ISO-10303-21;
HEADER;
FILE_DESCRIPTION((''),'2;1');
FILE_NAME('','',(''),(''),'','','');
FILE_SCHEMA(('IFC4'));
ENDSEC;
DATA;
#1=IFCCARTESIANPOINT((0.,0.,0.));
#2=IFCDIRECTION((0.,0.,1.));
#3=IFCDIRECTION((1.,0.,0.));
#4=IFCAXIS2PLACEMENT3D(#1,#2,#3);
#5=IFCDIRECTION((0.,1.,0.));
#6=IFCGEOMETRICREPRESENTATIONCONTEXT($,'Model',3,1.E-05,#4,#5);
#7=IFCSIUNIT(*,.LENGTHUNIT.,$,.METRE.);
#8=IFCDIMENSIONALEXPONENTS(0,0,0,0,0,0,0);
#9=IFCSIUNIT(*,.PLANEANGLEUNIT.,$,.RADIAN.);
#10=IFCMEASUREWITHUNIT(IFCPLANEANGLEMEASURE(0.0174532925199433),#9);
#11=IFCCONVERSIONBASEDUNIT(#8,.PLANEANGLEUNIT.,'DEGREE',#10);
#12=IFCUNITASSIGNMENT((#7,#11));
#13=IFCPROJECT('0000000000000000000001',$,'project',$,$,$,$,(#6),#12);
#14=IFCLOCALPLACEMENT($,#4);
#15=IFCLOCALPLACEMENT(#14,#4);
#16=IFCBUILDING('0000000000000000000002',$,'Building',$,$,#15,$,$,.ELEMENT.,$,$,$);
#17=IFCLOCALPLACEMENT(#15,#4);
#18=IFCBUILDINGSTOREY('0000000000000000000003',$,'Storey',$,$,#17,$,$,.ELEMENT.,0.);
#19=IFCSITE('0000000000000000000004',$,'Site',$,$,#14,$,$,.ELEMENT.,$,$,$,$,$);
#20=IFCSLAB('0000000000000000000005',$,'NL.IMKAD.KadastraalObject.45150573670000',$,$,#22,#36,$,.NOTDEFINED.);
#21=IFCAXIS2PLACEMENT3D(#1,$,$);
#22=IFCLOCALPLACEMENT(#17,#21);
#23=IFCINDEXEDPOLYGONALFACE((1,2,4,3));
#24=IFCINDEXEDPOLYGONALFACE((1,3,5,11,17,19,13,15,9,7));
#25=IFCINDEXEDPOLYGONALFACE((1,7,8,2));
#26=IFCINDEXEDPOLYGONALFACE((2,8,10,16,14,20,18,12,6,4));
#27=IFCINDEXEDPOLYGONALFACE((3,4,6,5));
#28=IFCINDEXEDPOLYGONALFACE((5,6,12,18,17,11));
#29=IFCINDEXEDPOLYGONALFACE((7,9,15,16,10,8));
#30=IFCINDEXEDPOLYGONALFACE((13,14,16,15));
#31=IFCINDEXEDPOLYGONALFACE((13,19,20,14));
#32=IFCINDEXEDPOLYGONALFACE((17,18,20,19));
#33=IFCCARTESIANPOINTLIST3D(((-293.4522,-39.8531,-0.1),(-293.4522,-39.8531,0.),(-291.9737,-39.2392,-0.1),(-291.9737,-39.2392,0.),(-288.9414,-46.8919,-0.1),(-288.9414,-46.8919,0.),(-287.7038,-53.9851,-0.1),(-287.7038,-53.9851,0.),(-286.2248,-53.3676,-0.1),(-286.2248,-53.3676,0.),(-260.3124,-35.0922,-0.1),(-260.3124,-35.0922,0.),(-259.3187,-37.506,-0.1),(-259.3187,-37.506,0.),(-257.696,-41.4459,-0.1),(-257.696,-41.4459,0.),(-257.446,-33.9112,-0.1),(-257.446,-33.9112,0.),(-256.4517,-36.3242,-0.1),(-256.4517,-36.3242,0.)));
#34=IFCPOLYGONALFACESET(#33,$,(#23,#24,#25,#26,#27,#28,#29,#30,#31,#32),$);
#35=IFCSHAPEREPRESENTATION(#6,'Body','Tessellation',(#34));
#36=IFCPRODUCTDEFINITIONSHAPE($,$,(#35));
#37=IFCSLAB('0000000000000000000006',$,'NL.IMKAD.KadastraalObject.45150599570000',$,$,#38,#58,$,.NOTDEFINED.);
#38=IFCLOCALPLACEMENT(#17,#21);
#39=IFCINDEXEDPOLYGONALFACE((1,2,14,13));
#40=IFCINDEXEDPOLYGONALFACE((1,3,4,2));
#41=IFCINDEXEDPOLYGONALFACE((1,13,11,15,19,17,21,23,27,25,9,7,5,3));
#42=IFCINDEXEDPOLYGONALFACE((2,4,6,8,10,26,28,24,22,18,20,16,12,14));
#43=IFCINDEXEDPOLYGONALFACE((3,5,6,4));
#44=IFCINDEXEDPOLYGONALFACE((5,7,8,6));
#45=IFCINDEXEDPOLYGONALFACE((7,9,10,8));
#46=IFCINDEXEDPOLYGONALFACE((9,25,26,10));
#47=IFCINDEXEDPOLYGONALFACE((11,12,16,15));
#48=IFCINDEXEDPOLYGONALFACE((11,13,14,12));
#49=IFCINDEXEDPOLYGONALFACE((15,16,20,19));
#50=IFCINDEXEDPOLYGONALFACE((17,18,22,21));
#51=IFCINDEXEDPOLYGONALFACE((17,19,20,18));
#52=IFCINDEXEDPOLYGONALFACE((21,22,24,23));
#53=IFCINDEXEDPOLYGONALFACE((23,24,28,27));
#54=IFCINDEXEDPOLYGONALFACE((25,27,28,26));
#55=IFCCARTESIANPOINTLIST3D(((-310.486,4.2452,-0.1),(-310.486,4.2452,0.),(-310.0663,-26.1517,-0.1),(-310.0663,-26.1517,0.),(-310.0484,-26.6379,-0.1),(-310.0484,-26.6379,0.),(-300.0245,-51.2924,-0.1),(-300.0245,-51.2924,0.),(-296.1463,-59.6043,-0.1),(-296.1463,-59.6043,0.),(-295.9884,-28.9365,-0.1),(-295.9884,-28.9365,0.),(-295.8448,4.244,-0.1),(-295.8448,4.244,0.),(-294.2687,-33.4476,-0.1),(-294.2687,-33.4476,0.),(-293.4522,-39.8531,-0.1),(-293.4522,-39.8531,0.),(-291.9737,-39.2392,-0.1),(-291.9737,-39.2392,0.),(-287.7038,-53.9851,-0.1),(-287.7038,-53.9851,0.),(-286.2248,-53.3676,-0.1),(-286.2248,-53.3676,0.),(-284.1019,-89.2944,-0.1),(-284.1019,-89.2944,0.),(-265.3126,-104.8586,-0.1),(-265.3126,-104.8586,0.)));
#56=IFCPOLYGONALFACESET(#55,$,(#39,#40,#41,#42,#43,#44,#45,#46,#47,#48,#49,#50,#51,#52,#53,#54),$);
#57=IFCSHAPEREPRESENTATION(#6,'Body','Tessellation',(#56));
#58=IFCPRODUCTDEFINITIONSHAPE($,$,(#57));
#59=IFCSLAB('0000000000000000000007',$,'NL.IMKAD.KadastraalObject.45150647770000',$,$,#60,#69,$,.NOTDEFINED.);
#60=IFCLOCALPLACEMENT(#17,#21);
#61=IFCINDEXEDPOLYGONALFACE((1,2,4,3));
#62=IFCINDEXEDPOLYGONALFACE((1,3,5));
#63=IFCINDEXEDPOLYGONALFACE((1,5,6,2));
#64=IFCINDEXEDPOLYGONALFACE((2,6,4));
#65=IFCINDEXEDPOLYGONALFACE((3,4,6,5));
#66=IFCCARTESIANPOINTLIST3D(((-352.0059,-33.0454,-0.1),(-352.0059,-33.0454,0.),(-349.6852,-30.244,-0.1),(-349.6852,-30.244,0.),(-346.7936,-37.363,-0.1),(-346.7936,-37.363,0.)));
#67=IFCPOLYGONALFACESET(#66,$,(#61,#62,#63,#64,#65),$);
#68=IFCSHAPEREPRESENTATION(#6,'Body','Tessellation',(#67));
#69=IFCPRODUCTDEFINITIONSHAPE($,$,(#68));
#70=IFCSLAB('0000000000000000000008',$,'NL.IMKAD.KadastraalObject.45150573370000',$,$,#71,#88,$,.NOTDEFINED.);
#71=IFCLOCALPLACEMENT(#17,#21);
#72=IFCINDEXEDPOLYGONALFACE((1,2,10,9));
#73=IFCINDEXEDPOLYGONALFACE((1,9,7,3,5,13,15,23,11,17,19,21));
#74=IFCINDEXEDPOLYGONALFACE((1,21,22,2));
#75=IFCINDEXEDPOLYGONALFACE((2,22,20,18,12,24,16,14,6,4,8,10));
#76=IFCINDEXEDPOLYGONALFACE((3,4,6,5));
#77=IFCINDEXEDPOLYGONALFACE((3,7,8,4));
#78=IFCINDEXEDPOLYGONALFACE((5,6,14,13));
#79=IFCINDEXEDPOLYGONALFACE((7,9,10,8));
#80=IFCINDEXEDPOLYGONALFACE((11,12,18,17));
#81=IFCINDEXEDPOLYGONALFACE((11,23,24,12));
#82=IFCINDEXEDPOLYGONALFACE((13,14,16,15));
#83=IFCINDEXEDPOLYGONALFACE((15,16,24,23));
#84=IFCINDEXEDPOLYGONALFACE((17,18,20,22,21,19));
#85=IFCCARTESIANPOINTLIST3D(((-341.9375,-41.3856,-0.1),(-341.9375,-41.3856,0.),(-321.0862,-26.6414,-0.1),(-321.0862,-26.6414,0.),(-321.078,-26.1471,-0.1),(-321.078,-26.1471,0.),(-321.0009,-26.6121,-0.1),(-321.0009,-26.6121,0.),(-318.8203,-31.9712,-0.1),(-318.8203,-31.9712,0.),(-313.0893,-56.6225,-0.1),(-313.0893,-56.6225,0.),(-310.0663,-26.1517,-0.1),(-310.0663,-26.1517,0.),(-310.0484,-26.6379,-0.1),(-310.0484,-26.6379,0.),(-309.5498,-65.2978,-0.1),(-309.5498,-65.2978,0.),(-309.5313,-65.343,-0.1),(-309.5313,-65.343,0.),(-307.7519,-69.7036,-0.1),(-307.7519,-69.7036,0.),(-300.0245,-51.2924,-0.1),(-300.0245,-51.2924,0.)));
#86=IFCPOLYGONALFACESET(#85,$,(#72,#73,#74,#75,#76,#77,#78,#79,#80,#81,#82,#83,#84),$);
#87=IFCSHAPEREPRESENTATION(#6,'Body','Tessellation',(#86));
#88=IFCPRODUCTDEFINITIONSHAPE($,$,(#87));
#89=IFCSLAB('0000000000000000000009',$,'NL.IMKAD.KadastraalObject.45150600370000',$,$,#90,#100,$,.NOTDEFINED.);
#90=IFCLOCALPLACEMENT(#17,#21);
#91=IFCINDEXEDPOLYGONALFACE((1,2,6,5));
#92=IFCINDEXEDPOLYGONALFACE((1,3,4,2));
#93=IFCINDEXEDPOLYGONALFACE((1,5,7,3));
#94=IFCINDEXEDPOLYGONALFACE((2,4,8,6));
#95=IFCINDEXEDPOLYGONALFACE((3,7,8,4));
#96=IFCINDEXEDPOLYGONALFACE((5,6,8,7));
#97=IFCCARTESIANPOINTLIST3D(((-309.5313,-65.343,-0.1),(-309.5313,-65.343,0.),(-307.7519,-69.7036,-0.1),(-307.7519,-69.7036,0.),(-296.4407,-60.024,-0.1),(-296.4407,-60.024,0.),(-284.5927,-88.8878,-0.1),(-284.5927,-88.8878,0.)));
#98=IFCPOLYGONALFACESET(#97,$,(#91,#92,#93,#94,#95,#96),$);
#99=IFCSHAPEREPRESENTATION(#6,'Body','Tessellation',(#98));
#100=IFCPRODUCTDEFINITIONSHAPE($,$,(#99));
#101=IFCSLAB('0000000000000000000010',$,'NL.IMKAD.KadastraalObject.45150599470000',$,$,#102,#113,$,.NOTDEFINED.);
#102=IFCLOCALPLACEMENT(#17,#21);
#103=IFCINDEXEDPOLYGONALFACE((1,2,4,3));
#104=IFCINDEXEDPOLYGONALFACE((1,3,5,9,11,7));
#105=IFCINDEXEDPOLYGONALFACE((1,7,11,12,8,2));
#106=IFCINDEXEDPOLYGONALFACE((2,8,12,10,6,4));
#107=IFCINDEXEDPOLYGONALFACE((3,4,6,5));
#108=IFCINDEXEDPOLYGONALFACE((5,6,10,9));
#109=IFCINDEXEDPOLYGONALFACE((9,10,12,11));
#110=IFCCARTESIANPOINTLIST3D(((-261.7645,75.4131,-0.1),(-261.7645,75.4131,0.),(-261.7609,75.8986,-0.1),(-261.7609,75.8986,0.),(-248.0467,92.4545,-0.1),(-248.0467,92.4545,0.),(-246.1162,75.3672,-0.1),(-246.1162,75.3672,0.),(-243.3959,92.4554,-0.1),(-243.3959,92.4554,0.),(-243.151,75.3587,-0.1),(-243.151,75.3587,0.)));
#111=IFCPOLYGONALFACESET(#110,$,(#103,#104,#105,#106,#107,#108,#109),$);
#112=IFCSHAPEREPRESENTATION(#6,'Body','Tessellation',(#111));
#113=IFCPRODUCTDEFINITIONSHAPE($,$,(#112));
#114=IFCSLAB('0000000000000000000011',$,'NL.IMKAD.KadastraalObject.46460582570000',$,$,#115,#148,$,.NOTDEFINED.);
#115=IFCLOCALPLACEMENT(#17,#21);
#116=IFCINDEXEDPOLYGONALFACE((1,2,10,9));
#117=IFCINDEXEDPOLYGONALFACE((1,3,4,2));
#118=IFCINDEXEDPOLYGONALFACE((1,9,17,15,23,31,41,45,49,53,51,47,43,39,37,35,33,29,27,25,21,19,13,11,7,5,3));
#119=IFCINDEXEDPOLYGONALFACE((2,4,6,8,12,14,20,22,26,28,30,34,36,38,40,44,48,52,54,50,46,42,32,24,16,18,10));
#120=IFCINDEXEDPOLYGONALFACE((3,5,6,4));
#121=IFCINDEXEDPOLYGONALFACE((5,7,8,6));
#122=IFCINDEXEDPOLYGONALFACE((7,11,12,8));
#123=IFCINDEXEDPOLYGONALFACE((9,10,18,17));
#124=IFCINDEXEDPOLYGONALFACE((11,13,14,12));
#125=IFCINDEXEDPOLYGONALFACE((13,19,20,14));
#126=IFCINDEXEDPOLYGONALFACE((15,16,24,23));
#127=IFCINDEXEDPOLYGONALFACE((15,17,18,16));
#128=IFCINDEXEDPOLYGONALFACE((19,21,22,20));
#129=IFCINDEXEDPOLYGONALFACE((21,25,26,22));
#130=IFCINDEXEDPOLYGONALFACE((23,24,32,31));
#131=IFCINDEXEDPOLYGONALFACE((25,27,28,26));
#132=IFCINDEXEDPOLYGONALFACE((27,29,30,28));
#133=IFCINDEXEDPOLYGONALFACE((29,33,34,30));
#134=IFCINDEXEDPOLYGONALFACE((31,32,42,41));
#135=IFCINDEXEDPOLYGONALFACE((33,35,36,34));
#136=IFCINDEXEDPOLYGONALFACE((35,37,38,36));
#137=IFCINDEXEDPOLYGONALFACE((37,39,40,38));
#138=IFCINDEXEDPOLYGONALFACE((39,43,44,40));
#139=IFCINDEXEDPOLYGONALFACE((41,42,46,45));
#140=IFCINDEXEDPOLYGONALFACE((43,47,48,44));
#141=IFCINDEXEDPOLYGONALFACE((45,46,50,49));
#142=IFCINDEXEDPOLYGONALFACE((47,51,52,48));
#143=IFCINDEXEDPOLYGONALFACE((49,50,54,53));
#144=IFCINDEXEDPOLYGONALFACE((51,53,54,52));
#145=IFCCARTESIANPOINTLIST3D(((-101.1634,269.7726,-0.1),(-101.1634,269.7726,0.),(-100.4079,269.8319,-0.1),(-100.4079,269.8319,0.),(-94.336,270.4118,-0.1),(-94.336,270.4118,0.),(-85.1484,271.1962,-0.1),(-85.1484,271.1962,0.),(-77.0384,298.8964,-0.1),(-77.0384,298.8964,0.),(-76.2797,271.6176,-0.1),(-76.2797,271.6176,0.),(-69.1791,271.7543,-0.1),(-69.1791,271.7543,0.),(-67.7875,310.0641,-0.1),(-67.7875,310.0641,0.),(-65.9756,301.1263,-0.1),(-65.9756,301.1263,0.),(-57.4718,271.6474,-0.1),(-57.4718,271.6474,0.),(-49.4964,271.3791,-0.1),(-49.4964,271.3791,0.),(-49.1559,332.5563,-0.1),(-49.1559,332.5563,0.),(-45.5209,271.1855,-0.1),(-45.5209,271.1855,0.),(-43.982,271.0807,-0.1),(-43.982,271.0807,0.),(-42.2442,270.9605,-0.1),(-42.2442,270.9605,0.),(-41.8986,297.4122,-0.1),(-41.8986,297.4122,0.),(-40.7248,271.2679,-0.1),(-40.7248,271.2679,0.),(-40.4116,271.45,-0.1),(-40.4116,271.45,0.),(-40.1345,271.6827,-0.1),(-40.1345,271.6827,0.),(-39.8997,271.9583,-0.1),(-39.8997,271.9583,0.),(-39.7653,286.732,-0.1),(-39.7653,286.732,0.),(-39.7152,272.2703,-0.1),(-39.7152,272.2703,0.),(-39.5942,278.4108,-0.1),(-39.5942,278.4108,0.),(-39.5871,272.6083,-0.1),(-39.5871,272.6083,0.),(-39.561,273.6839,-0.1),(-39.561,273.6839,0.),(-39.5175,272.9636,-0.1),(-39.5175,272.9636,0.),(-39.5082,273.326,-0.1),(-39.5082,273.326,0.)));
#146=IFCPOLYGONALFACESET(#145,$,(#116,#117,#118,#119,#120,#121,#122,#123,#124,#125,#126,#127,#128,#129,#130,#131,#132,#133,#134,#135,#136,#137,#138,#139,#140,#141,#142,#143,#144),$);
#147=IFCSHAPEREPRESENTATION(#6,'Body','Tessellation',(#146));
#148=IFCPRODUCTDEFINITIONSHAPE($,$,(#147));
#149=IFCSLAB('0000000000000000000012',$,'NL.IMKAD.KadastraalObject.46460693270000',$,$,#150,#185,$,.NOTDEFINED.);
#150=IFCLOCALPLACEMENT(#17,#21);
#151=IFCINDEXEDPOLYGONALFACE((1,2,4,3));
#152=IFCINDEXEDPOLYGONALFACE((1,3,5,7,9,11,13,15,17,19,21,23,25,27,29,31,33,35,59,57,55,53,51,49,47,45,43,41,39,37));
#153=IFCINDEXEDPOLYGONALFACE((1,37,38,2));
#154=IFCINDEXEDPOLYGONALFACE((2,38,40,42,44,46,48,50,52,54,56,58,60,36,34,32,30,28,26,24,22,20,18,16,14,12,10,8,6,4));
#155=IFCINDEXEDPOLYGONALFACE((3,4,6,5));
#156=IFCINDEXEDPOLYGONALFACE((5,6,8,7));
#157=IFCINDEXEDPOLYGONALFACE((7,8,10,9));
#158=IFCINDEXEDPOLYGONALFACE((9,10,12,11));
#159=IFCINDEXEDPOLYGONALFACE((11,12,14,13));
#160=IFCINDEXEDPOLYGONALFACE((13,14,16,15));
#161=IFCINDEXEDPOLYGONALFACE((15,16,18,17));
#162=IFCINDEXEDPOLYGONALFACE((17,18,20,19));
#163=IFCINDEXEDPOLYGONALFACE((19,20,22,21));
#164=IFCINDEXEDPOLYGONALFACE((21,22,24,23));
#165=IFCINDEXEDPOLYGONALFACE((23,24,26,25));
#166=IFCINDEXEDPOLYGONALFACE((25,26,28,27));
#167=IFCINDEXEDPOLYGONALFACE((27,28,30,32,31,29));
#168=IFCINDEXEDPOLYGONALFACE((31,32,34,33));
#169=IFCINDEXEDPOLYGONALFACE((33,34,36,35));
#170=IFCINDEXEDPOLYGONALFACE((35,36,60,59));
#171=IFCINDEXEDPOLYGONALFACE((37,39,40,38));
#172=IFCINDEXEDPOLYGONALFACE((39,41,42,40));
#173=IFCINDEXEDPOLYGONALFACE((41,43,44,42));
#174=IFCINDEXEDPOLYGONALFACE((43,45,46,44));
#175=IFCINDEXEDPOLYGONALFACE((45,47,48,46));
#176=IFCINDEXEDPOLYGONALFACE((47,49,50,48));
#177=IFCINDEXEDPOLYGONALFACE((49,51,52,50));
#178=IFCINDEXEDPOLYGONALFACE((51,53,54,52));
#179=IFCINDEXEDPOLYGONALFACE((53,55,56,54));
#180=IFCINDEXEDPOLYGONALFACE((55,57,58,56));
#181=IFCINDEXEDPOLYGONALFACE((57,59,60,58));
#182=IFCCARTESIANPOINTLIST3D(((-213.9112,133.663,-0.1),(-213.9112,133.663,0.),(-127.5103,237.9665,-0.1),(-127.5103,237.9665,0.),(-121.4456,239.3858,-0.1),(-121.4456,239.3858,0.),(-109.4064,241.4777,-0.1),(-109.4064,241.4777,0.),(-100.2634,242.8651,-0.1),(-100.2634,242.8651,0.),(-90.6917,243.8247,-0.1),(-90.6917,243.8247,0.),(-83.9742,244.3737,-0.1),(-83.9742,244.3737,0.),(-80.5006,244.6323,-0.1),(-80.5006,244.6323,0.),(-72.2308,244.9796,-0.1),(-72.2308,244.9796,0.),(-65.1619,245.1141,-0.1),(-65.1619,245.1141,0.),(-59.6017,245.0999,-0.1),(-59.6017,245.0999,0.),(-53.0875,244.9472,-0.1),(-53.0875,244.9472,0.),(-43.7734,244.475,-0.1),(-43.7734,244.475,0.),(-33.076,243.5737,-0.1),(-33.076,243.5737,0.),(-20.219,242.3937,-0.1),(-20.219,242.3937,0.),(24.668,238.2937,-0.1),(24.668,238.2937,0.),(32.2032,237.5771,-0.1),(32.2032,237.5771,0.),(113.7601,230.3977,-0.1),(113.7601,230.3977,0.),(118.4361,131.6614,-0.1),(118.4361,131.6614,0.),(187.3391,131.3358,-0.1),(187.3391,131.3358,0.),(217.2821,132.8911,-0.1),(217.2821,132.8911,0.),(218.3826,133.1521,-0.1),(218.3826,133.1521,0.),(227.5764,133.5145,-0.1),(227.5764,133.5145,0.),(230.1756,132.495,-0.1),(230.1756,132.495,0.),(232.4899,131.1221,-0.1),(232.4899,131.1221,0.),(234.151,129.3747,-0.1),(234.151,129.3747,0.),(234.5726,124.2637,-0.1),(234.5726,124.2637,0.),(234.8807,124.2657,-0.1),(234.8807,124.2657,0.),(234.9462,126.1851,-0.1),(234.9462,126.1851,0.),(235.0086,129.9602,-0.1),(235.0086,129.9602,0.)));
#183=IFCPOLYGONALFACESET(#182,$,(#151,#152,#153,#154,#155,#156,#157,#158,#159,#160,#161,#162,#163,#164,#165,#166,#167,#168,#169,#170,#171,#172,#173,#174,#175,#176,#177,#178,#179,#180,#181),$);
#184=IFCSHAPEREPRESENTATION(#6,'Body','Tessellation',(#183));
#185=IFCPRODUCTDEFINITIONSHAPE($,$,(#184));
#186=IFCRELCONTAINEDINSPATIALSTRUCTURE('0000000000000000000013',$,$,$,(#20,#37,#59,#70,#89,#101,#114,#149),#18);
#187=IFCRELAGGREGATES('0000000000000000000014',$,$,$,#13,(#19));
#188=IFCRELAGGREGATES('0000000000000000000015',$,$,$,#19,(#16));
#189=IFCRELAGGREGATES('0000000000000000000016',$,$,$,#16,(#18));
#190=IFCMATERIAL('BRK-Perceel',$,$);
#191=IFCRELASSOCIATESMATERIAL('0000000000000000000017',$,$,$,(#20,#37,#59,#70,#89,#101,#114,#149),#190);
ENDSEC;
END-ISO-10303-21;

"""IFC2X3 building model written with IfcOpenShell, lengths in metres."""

from ifc_helpers import new_model, entity, si_unit, converted_unit, direction, frame, origin_with_axes, place, context, project, spatial, polyline, outline, extrude, material, element, save


model = new_model("IFC2X3")

# Units and contexts
model_context = context("Model", 3, precision=1e-05, world=origin_with_axes(), true_north=direction((0.0, 1.0, 0.0)))
ifc_project = project(units=[si_unit("LENGTHUNIT", "METRE"), converted_unit("PLANEANGLEUNIT", "DEGREE", entity("IfcPlaneAngleMeasure", 0.0174532925199433), si_unit("PLANEANGLEUNIT", "RADIAN"), dimensions=[0, 0, 0, 0, 0, 0, 0])], contexts=[model_context])

# Site, building, storey
site_placement = place(None, origin_with_axes())
site = spatial("IfcSite", under=ifc_project, at=site_placement, Name="Site", CompositionType="ELEMENT")
building_placement = place(site_placement, origin_with_axes())
building = spatial("IfcBuilding", under=site, at=building_placement, Name="Building", CompositionType="ELEMENT")
storey_placement = place(building_placement, origin_with_axes())
storey = spatial("IfcBuildingStorey", under=building, at=storey_placement, Name="Storey", CompositionType="ELEMENT", Elevation=0.0)

# Slabs
ifc_material = material(Name="BRK-Perceel")
slab_1_placement = place(storey_placement, frame((0.0, 0.0, -0.1), z_axis=(0.0, 0.0, 1.0), x_axis=(1.0, 0.0, 0.0)))
element("IfcSlab", 1, at=slab_1_placement, inside=storey, material=ifc_material, Name="NL.IMKAD.KadastraalObject.45150573670000", PredefinedType="NOTDEFINED", context=model_context, shape_type="SweptSolid", body=[
    extrude(outline(polyline([(-256.4517, -36.3242), (-259.3187, -37.506), (-257.696, -41.4459), (-286.2248, -53.3676), (-287.7038, -53.9851), (-293.4522, -39.8531), (-291.9737, -39.2392), (-288.9414, -46.8919), (-260.3124, -35.0922), (-257.446, -33.9112), (-256.4517, -36.3242)])), origin_with_axes(), (0.0, 0.0, 1.0), 0.1),
])
slab_2_placement = place(storey_placement, frame((0.0, 0.0, -0.1), z_axis=(0.0, 0.0, 1.0), x_axis=(1.0, 0.0, 0.0)))
element("IfcSlab", 2, at=slab_2_placement, inside=storey, material=ifc_material, Name="NL.IMKAD.KadastraalObject.45150599570000", PredefinedType="NOTDEFINED", context=model_context, shape_type="SweptSolid", body=[
    extrude(outline(polyline([(-296.1463, -59.6043), (-300.0245, -51.2924), (-310.0484, -26.6379), (-310.0663, -26.1517), (-310.486, 4.2452), (-295.8448, 4.244), (-295.9884, -28.9365), (-294.2687, -33.4476), (-291.9737, -39.2392), (-293.4522, -39.8531), (-287.7038, -53.9851), (-286.2248, -53.3676), (-265.3126, -104.8586), (-284.1019, -89.2944), (-296.1463, -59.6043)])), origin_with_axes(), (0.0, 0.0, 1.0), 0.1),
])
slab_3_placement = place(storey_placement, frame((0.0, 0.0, -0.1), z_axis=(0.0, 0.0, 1.0), x_axis=(1.0, 0.0, 0.0)))
element("IfcSlab", 3, at=slab_3_placement, inside=storey, material=ifc_material, Name="NL.IMKAD.KadastraalObject.45150647770000", PredefinedType="NOTDEFINED", context=model_context, shape_type="SweptSolid", body=[
    extrude(outline(polyline([(-346.7936, -37.363), (-352.0059, -33.0454), (-349.6852, -30.244), (-346.7936, -37.363)])), origin_with_axes(), (0.0, 0.0, 1.0), 0.1),
])
slab_4_placement = place(storey_placement, frame((0.0, 0.0, -0.1), z_axis=(0.0, 0.0, 1.0), x_axis=(1.0, 0.0, 0.0)))
element("IfcSlab", 4, at=slab_4_placement, inside=storey, material=ifc_material, Name="NL.IMKAD.KadastraalObject.45150573370000", PredefinedType="NOTDEFINED", context=model_context, shape_type="SweptSolid", body=[
    extrude(outline(polyline([(-318.8203, -31.9712), (-321.0009, -26.6121), (-321.0862, -26.6414), (-321.078, -26.1471), (-310.0663, -26.1517), (-310.0484, -26.6379), (-300.0245, -51.2924), (-313.0893, -56.6225), (-309.5498, -65.2978), (-309.5313, -65.343), (-307.7519, -69.7036), (-341.9375, -41.3856), (-318.8203, -31.9712)])), origin_with_axes(), (0.0, 0.0, 1.0), 0.1),
])
slab_5_placement = place(storey_placement, frame((0.0, 0.0, -0.1), z_axis=(0.0, 0.0, 1.0), x_axis=(1.0, 0.0, 0.0)))
element("IfcSlab", 5, at=slab_5_placement, inside=storey, material=ifc_material, Name="NL.IMKAD.KadastraalObject.45150600370000", PredefinedType="NOTDEFINED", context=model_context, shape_type="SweptSolid", body=[
    extrude(outline(polyline([(-309.5313, -65.343), (-296.4407, -60.024), (-284.5927, -88.8878), (-307.7519, -69.7036), (-309.5313, -65.343)])), origin_with_axes(), (0.0, 0.0, 1.0), 0.1),
])
slab_6_placement = place(storey_placement, frame((0.0, 0.0, -0.1), z_axis=(0.0, 0.0, 1.0), x_axis=(1.0, 0.0, 0.0)))
element("IfcSlab", 6, at=slab_6_placement, inside=storey, material=ifc_material, Name="NL.IMKAD.KadastraalObject.45150599470000", PredefinedType="NOTDEFINED", context=model_context, shape_type="SweptSolid", body=[
    extrude(outline(polyline([(-243.3959, 92.4554), (-243.151, 75.3587), (-246.1162, 75.3672), (-261.7645, 75.4131), (-261.7609, 75.8986), (-248.0467, 92.4545), (-243.3959, 92.4554)])), origin_with_axes(), (0.0, 0.0, 1.0), 0.1),
])
slab_7_placement = place(storey_placement, frame((0.0, 0.0, -0.1), z_axis=(0.0, 0.0, 1.0), x_axis=(1.0, 0.0, 0.0)))
element("IfcSlab", 7, at=slab_7_placement, inside=storey, material=ifc_material, Name="NL.IMKAD.KadastraalObject.46460582570000", PredefinedType="NOTDEFINED", context=model_context, shape_type="SweptSolid", body=[
    extrude(outline(polyline([(-65.9756, 301.1263), (-67.7875, 310.0641), (-49.1559, 332.5563), (-41.8986, 297.4122), (-39.7653, 286.732), (-39.5942, 278.4108), (-39.561, 273.6839), (-39.5082, 273.326), (-39.5175, 272.9636), (-39.5871, 272.6083), (-39.7152, 272.2703), (-39.8997, 271.9583), (-40.1345, 271.6827), (-40.4116, 271.45), (-40.7248, 271.2679), (-42.2442, 270.9605), (-43.982, 271.0807), (-45.5209, 271.1855), (-49.4964, 271.3791), (-57.4718, 271.6474), (-69.1791, 271.7543), (-76.2797, 271.6176), (-85.1484, 271.1962), (-94.336, 270.4118), (-100.4079, 269.8319), (-101.1634, 269.7726), (-77.0384, 298.8964), (-65.9756, 301.1263)])), origin_with_axes(), (0.0, 0.0, 1.0), 0.1),
])
slab_8_placement = place(storey_placement, frame((0.0, 0.0, -0.1), z_axis=(0.0, 0.0, 1.0), x_axis=(1.0, 0.0, 0.0)))
element("IfcSlab", 8, at=slab_8_placement, inside=storey, material=ifc_material, Name="NL.IMKAD.KadastraalObject.46460693270000", PredefinedType="NOTDEFINED", context=model_context, shape_type="SweptSolid", body=[
    extrude(outline(polyline([(234.9462, 126.1851), (234.8807, 124.2657), (234.5726, 124.2637), (234.151, 129.3747), (232.4899, 131.1221), (230.1756, 132.495), (227.5764, 133.5145), (218.3826, 133.1521), (217.2821, 132.8911), (187.3391, 131.3358), (118.4361, 131.6614), (-213.9112, 133.663), (-127.5103, 237.9665), (-121.4456, 239.3858), (-109.4064, 241.4777), (-100.2634, 242.8651), (-90.6917, 243.8247), (-83.9742, 244.3737), (-80.5006, 244.6323), (-72.2308, 244.9796), (-65.1619, 245.1141), (-59.6017, 245.0999), (-53.0875, 244.9472), (-43.7734, 244.475), (-33.076, 243.5737), (-20.219, 242.3937), (24.668, 238.2937), (32.2032, 237.5771), (113.7601, 230.3977), (235.0086, 129.9602), (234.9462, 126.1851)])), origin_with_axes(), (0.0, 0.0, 1.0), 0.1),
])

save(model, "model.ifc")
